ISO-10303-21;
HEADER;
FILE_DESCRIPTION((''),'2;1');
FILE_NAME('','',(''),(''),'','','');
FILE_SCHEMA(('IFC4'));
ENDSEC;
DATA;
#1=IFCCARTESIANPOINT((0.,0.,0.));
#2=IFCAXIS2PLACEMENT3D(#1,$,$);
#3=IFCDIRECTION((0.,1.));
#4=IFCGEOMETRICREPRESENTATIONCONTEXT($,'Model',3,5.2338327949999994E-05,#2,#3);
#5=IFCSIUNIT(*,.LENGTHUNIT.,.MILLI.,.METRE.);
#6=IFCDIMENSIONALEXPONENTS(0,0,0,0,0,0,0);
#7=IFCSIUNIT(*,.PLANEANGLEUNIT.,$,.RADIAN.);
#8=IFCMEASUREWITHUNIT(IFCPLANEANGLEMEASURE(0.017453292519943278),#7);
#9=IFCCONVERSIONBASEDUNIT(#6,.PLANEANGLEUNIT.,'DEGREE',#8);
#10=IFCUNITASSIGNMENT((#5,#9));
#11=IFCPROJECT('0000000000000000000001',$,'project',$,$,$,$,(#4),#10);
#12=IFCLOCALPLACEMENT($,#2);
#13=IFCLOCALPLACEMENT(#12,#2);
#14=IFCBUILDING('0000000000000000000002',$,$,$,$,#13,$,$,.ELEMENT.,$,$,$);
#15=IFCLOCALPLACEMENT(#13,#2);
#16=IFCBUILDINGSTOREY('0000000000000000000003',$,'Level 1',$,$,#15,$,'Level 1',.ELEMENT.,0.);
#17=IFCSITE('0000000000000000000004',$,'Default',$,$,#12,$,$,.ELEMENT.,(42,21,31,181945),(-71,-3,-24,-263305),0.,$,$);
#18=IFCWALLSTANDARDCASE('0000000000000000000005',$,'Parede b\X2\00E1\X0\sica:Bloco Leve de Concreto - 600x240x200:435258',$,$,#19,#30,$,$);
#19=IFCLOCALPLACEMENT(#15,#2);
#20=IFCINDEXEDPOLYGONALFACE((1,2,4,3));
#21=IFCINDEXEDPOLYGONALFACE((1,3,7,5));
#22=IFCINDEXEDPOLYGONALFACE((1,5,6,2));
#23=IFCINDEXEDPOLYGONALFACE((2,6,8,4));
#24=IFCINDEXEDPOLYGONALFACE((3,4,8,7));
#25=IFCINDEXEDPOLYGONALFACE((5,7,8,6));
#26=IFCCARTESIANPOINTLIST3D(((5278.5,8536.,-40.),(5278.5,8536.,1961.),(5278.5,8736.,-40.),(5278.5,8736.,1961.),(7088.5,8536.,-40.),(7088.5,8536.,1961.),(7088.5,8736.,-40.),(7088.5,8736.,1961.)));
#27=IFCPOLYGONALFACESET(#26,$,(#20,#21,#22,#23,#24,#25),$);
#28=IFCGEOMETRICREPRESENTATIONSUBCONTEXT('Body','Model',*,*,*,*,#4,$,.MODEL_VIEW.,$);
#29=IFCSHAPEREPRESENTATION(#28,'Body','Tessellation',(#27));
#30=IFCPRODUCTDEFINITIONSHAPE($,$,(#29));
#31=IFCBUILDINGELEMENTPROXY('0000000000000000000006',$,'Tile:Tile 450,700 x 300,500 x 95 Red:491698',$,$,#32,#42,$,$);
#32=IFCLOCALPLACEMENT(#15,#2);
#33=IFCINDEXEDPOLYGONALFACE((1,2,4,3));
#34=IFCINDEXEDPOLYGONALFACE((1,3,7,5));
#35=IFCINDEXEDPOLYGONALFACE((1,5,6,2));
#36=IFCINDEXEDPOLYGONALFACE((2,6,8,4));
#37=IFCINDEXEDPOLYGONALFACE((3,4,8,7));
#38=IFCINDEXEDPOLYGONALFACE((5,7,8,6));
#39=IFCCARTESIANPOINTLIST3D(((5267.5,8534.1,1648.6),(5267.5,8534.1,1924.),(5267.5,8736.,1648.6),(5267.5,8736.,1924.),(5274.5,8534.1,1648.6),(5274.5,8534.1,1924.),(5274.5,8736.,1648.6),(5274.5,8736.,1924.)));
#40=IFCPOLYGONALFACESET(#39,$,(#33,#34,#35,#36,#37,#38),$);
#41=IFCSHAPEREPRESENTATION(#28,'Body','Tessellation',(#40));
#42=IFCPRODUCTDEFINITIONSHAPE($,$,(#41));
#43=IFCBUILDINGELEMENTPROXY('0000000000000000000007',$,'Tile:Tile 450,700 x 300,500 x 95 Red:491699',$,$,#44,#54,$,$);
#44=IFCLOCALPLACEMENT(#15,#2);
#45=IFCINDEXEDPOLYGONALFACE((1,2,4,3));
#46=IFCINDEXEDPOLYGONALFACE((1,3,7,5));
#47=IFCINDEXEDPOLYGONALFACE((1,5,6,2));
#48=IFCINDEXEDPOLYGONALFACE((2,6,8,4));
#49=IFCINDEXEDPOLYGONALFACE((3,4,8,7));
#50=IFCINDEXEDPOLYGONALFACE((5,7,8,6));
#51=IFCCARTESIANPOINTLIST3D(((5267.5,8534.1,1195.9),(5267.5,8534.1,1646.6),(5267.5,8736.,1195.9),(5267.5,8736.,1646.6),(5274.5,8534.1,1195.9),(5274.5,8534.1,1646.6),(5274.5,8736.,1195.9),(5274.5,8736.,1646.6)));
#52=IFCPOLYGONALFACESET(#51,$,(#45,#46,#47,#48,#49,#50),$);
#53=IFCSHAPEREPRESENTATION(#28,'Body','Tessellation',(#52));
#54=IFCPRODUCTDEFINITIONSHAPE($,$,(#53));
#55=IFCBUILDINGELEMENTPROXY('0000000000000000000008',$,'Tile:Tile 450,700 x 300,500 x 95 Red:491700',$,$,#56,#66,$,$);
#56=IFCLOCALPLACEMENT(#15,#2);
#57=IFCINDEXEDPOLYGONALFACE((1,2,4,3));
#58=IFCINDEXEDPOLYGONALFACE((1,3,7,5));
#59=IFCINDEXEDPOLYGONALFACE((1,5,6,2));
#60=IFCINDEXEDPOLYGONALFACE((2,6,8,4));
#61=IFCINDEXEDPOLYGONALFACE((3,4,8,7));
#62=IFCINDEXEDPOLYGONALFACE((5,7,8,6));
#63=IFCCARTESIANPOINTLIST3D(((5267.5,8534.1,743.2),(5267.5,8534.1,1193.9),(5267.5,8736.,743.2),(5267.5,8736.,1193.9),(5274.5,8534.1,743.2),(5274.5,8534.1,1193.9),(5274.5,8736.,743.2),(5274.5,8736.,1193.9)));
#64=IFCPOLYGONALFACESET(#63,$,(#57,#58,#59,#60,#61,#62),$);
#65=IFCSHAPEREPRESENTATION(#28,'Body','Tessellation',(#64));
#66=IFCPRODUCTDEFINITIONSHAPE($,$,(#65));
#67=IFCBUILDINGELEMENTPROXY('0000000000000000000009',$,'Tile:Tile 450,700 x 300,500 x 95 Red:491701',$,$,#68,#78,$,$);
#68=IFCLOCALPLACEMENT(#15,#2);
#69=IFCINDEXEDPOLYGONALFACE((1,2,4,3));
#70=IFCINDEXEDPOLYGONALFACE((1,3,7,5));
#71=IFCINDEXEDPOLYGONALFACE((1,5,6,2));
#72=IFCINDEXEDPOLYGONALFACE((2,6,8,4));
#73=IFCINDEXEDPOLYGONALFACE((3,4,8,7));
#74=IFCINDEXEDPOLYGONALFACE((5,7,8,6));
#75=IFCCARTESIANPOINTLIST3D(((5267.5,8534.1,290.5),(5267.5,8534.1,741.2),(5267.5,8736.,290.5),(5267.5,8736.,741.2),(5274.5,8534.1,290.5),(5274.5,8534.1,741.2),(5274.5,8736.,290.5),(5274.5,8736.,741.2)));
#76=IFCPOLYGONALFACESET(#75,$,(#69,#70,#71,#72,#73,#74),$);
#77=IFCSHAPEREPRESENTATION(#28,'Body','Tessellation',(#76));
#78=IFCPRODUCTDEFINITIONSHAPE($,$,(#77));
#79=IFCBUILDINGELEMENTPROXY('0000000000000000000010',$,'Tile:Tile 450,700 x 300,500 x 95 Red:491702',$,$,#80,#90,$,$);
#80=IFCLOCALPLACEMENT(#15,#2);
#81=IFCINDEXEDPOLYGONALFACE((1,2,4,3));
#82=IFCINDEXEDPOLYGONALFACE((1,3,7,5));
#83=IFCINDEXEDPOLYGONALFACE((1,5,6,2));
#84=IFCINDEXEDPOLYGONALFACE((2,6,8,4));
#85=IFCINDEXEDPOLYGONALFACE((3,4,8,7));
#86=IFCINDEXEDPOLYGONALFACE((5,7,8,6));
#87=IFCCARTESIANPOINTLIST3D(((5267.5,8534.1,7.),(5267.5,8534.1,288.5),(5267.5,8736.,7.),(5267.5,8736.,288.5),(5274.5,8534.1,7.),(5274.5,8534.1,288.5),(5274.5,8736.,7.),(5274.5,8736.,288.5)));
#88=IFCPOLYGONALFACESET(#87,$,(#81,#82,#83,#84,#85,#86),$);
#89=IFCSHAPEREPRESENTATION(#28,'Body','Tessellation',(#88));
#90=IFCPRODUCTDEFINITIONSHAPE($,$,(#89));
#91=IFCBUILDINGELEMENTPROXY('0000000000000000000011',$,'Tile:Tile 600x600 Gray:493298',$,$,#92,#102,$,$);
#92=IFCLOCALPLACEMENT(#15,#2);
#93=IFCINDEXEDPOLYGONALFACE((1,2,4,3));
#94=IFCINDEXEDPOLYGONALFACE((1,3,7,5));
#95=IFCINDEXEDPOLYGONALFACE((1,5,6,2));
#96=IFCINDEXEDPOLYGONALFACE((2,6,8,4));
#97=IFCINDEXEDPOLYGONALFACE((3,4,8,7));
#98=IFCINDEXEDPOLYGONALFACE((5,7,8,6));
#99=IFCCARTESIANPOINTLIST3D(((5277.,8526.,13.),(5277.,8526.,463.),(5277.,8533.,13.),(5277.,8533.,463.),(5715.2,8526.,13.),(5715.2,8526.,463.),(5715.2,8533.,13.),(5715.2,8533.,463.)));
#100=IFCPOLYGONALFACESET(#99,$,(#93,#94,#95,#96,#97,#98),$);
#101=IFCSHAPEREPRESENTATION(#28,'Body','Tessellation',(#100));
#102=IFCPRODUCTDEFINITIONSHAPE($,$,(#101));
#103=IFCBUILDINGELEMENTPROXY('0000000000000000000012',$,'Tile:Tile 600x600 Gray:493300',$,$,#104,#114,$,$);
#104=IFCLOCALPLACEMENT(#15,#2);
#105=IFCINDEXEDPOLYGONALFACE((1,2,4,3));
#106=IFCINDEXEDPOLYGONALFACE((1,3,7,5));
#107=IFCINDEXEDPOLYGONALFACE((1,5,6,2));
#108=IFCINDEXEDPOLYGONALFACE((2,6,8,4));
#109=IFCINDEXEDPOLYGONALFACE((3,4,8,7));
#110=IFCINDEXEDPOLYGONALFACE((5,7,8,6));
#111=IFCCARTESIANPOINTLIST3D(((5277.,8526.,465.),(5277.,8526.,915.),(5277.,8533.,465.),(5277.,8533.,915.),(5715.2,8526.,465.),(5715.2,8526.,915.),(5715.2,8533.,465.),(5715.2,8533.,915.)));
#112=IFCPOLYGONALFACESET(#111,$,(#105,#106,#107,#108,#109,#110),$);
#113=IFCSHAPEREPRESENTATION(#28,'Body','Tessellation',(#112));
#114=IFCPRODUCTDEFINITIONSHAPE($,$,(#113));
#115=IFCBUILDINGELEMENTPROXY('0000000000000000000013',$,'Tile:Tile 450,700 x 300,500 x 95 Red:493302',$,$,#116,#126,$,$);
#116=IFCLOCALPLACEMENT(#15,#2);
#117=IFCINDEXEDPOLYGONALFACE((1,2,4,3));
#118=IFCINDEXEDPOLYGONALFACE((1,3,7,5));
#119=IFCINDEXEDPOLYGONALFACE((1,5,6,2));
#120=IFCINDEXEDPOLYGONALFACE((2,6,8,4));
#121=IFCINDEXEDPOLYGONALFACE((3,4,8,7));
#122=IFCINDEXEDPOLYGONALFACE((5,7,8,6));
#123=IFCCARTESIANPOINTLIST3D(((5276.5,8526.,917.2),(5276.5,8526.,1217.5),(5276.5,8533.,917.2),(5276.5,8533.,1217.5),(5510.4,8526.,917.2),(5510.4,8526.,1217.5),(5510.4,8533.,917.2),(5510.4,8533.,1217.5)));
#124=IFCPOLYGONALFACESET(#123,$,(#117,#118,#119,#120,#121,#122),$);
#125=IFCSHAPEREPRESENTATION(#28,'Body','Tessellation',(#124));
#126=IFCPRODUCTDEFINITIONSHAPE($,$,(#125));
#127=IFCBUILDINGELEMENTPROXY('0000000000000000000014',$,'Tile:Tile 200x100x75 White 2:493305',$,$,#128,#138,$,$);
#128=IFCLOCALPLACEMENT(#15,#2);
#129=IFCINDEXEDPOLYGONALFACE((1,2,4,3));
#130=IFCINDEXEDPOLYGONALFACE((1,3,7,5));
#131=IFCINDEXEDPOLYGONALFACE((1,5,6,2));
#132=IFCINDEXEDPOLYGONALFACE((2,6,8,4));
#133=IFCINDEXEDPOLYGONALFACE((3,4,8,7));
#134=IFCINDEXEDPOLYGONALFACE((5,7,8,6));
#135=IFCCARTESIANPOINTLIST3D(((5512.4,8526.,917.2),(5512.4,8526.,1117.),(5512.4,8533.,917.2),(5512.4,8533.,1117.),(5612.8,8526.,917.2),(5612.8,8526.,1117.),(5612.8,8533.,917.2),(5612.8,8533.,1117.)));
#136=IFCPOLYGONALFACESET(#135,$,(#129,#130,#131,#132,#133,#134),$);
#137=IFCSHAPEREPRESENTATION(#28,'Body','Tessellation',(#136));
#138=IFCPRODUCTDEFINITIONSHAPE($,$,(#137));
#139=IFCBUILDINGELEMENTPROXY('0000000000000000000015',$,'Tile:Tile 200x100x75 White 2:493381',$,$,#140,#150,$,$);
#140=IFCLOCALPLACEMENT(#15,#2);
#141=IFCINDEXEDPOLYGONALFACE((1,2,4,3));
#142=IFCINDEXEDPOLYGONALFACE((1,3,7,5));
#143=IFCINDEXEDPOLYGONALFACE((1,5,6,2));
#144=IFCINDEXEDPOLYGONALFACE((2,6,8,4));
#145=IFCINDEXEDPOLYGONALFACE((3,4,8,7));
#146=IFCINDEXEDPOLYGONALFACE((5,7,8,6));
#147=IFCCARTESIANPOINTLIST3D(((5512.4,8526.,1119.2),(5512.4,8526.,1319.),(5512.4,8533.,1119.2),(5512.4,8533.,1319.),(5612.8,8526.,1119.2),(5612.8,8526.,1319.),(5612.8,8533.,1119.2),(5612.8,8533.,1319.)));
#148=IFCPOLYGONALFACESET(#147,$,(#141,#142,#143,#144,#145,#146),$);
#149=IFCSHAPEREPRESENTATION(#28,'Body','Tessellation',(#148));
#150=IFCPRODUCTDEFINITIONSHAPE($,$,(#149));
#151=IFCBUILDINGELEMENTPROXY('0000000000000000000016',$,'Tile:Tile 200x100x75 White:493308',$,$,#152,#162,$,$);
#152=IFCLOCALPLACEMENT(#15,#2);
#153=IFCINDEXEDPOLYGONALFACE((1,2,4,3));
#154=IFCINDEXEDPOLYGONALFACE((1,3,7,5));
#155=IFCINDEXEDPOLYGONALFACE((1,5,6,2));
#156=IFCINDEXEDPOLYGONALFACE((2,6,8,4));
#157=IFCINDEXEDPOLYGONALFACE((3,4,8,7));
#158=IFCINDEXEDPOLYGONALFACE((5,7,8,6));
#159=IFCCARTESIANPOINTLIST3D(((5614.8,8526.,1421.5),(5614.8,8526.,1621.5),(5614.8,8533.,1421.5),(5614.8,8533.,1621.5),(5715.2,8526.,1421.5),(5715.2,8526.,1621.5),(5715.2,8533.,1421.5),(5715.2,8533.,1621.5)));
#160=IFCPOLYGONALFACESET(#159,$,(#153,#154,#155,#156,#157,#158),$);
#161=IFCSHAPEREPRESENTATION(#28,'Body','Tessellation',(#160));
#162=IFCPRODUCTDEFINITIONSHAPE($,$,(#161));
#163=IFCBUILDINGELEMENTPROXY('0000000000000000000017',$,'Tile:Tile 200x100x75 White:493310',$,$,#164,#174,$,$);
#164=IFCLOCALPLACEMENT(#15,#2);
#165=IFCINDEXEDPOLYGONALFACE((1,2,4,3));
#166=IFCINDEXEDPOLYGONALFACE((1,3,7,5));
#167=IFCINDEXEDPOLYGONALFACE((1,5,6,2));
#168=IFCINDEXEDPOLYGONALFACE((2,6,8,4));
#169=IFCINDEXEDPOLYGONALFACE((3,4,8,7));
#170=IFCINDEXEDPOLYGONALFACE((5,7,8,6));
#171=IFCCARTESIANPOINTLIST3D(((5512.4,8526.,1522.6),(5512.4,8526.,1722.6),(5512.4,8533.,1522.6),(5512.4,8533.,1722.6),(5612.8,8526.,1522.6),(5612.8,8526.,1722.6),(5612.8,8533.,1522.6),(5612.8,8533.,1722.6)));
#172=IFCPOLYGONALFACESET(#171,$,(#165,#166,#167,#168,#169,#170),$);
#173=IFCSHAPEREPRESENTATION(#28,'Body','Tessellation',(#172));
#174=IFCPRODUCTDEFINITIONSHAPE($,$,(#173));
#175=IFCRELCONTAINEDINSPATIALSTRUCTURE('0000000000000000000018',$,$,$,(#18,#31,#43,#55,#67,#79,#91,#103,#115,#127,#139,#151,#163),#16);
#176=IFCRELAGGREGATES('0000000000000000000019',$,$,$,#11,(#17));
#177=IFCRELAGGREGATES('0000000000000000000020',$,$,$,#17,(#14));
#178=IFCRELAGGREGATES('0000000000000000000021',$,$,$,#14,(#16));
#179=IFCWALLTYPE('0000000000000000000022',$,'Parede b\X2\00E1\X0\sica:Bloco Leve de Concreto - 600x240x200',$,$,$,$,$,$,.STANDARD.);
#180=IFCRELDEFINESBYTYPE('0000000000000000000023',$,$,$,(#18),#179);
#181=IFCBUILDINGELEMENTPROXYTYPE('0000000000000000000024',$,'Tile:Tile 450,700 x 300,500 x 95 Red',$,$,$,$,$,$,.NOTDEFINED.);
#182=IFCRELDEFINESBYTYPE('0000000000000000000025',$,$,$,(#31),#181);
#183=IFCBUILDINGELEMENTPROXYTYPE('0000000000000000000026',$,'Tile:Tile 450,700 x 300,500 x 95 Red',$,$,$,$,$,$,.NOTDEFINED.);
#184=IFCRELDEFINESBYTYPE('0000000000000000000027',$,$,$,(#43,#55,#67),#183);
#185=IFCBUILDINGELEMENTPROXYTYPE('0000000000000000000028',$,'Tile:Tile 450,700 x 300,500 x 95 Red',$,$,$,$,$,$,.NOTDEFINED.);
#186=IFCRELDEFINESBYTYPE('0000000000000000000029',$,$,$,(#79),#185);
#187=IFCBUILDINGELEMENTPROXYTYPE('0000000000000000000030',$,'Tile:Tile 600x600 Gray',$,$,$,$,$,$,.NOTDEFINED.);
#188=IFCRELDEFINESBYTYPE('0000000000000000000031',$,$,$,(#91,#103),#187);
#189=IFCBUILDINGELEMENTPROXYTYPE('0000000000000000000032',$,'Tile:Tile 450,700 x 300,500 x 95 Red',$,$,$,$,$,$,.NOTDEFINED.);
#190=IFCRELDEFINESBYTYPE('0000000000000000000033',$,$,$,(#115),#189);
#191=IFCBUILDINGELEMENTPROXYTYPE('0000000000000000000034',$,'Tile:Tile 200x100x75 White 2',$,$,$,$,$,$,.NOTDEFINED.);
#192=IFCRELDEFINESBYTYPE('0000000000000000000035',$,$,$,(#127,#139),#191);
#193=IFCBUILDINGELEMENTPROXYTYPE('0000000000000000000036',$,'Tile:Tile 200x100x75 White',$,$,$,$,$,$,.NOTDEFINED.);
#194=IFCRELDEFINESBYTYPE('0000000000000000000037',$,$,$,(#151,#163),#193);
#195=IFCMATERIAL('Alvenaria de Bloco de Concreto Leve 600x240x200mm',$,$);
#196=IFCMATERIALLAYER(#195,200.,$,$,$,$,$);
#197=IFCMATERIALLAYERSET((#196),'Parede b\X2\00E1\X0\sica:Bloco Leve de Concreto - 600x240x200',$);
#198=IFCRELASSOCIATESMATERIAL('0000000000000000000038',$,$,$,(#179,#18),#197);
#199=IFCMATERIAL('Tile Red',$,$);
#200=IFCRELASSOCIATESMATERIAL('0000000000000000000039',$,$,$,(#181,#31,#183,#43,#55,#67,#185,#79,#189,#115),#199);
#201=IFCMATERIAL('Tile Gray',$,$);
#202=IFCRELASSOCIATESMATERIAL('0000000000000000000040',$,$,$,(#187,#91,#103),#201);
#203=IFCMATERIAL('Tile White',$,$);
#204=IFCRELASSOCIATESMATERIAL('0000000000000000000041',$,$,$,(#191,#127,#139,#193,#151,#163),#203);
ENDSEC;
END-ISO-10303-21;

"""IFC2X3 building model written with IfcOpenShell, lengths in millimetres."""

from ifc_helpers import new_model, entity, si_unit, converted_unit, direction, frame, frame_2d, origin, origin_2d_with_axis, place, context, subcontext, project, spatial, rectangle, extrude, source, transform, mapped, material, layer, layer_set, layer_usage, type_object, type_shapes, element, save


model = new_model("IFC2X3")

# Units and contexts
model_context = context("Model", 3, precision=5.2338327949999994e-05, world=origin(), true_north=direction((0.0, 1.0)))
body_context = subcontext(model_context, "Body", "Model", "MODEL_VIEW")
ifc_project = project(units=[si_unit("LENGTHUNIT", "METRE", prefix="MILLI"), converted_unit("PLANEANGLEUNIT", "DEGREE", entity("IfcPlaneAngleMeasure", 0.017453292519943278), si_unit("PLANEANGLEUNIT", "RADIAN"), dimensions=[0, 0, 0, 0, 0, 0, 0])], contexts=[model_context])

# Site, building, storey
site_placement = place(None, origin())
site = spatial("IfcSite", under=ifc_project, at=site_placement, Name="Default", CompositionType="ELEMENT", RefLatitude=(42, 21, 31, 181945), RefLongitude=(-71, -3, -24, -263305), RefElevation=0.0)
building_placement = place(site_placement, origin())
building = spatial("IfcBuilding", under=site, at=building_placement, CompositionType="ELEMENT")
storey_placement = place(building_placement, origin())
storey = spatial("IfcBuildingStorey", under=building, at=storey_placement, Name="Level 1", LongName="Level 1", CompositionType="ELEMENT", Elevation=0.0)

# Wall
ifc_material_1 = material(Name="Alvenaria de Bloco de Concreto Leve 600x240x200mm")
ifc_layer = layer(ifc_material_1, 200.0)
ifc_layer_set = layer_set([ifc_layer], Name="Parede básica:Bloco Leve de Concreto - 600x240x200")
ifc_layer_usage = layer_usage(ifc_layer_set, "AXIS2", "NEGATIVE", 100.0)
wall_type = type_object("IfcWallType", Name="Parede básica:Bloco Leve de Concreto - 600x240x200", PredefinedType="STANDARD", material=ifc_layer_set)
wall_placement = place(storey_placement, frame((5278.5, 8636.0, -40.0)))
element("IfcWallStandardCase", 1, at=wall_placement, inside=storey, type_object=wall_type, material=ifc_layer_usage, Name="Parede básica:Bloco Leve de Concreto - 600x240x200:435258", context=body_context, shape_type="SweptSolid", body=[
    extrude(rectangle(XDim=1810.0, YDim=200.0, at=frame_2d((905.0, 0.0), x_axis=(-1.0, 0.0))), origin(), (0.0, 0.0, 1.0), 2001.0),
])

# Building element proxies
ifc_material_2 = material(Name="Tile Red")
building_element_proxy_type_1 = type_object("IfcBuildingElementProxyType", Name="Tile:Tile 450,700 x 300,500 x 95 Red", PredefinedType="NOTDEFINED", material=ifc_material_2)
shared_shape_1 = source(origin(), body_context, "Body", "SweptSolid", [
    extrude(rectangle(XDim=202.0, YDim=275.4, at=frame_2d((0.0, 0.0), x_axis=(1.0, 0.0))), frame((-101.0, -137.7, 0.0), z_axis=(0.0, 0.0, 1.0), x_axis=(-1.0, 0.0, 0.0)), (0.0, 0.0, 1.0), 7.0),
])
type_shapes(building_element_proxy_type_1, [shared_shape_1])
proxy_1_placement = place(storey_placement, frame((5274.5, 8736.0, 1648.6), z_axis=(-1.0, 0.0, 0.0), x_axis=(0.0, 1.0, 0.0)))
element("IfcBuildingElementProxy", 2, at=proxy_1_placement, inside=storey, type_object=building_element_proxy_type_1, material=ifc_material_2, Name="Tile:Tile 450,700 x 300,500 x 95 Red:491698", context=body_context, shape_type="MappedRepresentation", body=[
    mapped(shared_shape_1, transform((0.0, 0.0, 0.0), scale=1.0)),
])
building_element_proxy_type_2 = type_object("IfcBuildingElementProxyType", Name="Tile:Tile 450,700 x 300,500 x 95 Red", PredefinedType="NOTDEFINED", material=ifc_material_2)
shared_shape_2 = source(origin(), body_context, "Body", "SweptSolid", [
    extrude(rectangle(XDim=202.0, YDim=450.7, at=frame_2d((0.0, 0.0), x_axis=(1.0, 0.0))), frame((-101.0, -225.4, 0.0), z_axis=(0.0, 0.0, 1.0), x_axis=(-1.0, 0.0, 0.0)), (0.0, 0.0, 1.0), 7.0),
])
type_shapes(building_element_proxy_type_2, [shared_shape_2])
for number, where, z_axis, x_axis, name in (
    (3, (5274.5, 8736.0, 1195.9), (-1.0, 0.0, 0.0), (0.0, 1.0, 0.0), "Tile:Tile 450,700 x 300,500 x 95 Red:491699"),
    (4, (5274.5, 8736.0, 743.2), (-1.0, 0.0, 0.0), (0.0, 1.0, 0.0), "Tile:Tile 450,700 x 300,500 x 95 Red:491700"),
    (5, (5274.5, 8736.0, 290.5), (-1.0, 0.0, 0.0), (0.0, 1.0, 0.0), "Tile:Tile 450,700 x 300,500 x 95 Red:491701"),
):
    element("IfcBuildingElementProxy", number, at=place(storey_placement, frame(where, z_axis=z_axis, x_axis=x_axis)), inside=storey, type_object=building_element_proxy_type_2, material=ifc_material_2, Name=name, context=body_context, shape_type="MappedRepresentation", body=[
        mapped(shared_shape_2, transform((0.0, 0.0, 0.0), scale=1.0)),
    ])
building_element_proxy_type_3 = type_object("IfcBuildingElementProxyType", Name="Tile:Tile 450,700 x 300,500 x 95 Red", PredefinedType="NOTDEFINED", material=ifc_material_2)
shared_shape_3 = source(origin(), body_context, "Body", "SweptSolid", [
    extrude(rectangle(XDim=202.0, YDim=281.4, at=frame_2d((0.0, 0.0), x_axis=(1.0, 0.0))), frame((-101.0, -140.7, 0.0), z_axis=(0.0, 0.0, 1.0), x_axis=(-1.0, 0.0, 0.0)), (0.0, 0.0, 1.0), 7.0),
])
type_shapes(building_element_proxy_type_3, [shared_shape_3])
proxy_2_placement = place(storey_placement, frame((5274.5, 8736.0, 7.0), z_axis=(-1.0, 0.0, 0.0), x_axis=(0.0, 1.0, 0.0)))
element("IfcBuildingElementProxy", 6, at=proxy_2_placement, inside=storey, type_object=building_element_proxy_type_3, material=ifc_material_2, Name="Tile:Tile 450,700 x 300,500 x 95 Red:491702", context=body_context, shape_type="MappedRepresentation", body=[
    mapped(shared_shape_3, transform((0.0, 0.0, 0.0), scale=1.0)),
])
ifc_material_3 = material(Name="Tile Gray")
building_element_proxy_type_4 = type_object("IfcBuildingElementProxyType", Name="Tile:Tile 600x600 Gray", PredefinedType="NOTDEFINED", material=ifc_material_3)
shared_shape_4 = source(origin(), body_context, "Body", "SweptSolid", [
    extrude(rectangle(XDim=438.2, YDim=450.0, at=origin_2d_with_axis()), frame((-219.1, -225.0, 0.0), z_axis=(0.0, 0.0, 1.0), x_axis=(-1.0, 0.0, 0.0)), (0.0, 0.0, 1.0), 7.0),
])
type_shapes(building_element_proxy_type_4, [shared_shape_4])
for number, where, z_axis, x_axis, name in (
    (7, (5715.2, 8533.0, 463.0), (0.0, -1.0, 0.0), (1.0, 0.0, 0.0), "Tile:Tile 600x600 Gray:493298"),
    (8, (5715.2, 8533.0, 915.0), (0.0, -1.0, 0.0), (1.0, 0.0, 0.0), "Tile:Tile 600x600 Gray:493300"),
):
    element("IfcBuildingElementProxy", number, at=place(storey_placement, frame(where, z_axis=z_axis, x_axis=x_axis)), inside=storey, type_object=building_element_proxy_type_4, material=ifc_material_3, Name=name, context=body_context, shape_type="MappedRepresentation", body=[
        mapped(shared_shape_4, transform((0.0, 0.0, 0.0), scale=1.0)),
    ])
building_element_proxy_type_5 = type_object("IfcBuildingElementProxyType", Name="Tile:Tile 450,700 x 300,500 x 95 Red", PredefinedType="NOTDEFINED", material=ifc_material_2)
shared_shape_5 = source(origin(), body_context, "Body", "SweptSolid", [
    extrude(rectangle(XDim=233.9, YDim=300.3, at=frame_2d((0.0, 0.0), x_axis=(1.0, 0.0))), frame((-116.9, -150.2, 0.0), z_axis=(0.0, 0.0, 1.0), x_axis=(-1.0, 0.0, 0.0)), (0.0, 0.0, 1.0), 7.0),
])
type_shapes(building_element_proxy_type_5, [shared_shape_5])
proxy_3_placement = place(storey_placement, frame((5510.4, 8533.0, 1217.5), z_axis=(0.0, -1.0, 0.0), x_axis=(1.0, 0.0, 0.0)))
element("IfcBuildingElementProxy", 9, at=proxy_3_placement, inside=storey, type_object=building_element_proxy_type_5, material=ifc_material_2, Name="Tile:Tile 450,700 x 300,500 x 95 Red:493302", context=body_context, shape_type="MappedRepresentation", body=[
    mapped(shared_shape_5, transform((0.0, 0.0, 0.0), scale=1.0)),
])
ifc_material_4 = material(Name="Tile White")
building_element_proxy_type_6 = type_object("IfcBuildingElementProxyType", Name="Tile:Tile 200x100x75 White 2", PredefinedType="NOTDEFINED", material=ifc_material_4)
shared_shape_6 = source(origin(), body_context, "Body", "SweptSolid", [
    extrude(rectangle(XDim=199.8, YDim=100.4, at=frame_2d((0.0, 0.0), x_axis=(1.0, 0.0))), frame((-50.2, -99.9, 0.0), z_axis=(0.0, 0.0, 1.0), x_axis=(0.0, -1.0, 0.0)), (0.0, 0.0, 1.0), 7.0),
])
type_shapes(building_element_proxy_type_6, [shared_shape_6])
for number, where, z_axis, x_axis, name in (
    (10, (5612.8, 8533.0, 1117.0), (0.0, -1.0, 0.0), (1.0, 0.0, 0.0), "Tile:Tile 200x100x75 White 2:493305"),
    (11, (5612.8, 8533.0, 1319.0), (0.0, -1.0, 0.0), (1.0, 0.0, 0.0), "Tile:Tile 200x100x75 White 2:493381"),
):
    element("IfcBuildingElementProxy", number, at=place(storey_placement, frame(where, z_axis=z_axis, x_axis=x_axis)), inside=storey, type_object=building_element_proxy_type_6, material=ifc_material_4, Name=name, context=body_context, shape_type="MappedRepresentation", body=[
        mapped(shared_shape_6, transform((0.0, 0.0, 0.0), scale=1.0)),
    ])
building_element_proxy_type_7 = type_object("IfcBuildingElementProxyType", Name="Tile:Tile 200x100x75 White", PredefinedType="NOTDEFINED", material=ifc_material_4)
shared_shape_7 = source(origin(), body_context, "Body", "SweptSolid", [
    extrude(rectangle(XDim=200.0, YDim=100.4, at=frame_2d((0.0, 0.0), x_axis=(1.0, 0.0))), frame((-50.2, -100.0, 0.0), z_axis=(0.0, 0.0, 1.0), x_axis=(0.0, -1.0, 0.0)), (0.0, 0.0, 1.0), 7.0),
])
type_shapes(building_element_proxy_type_7, [shared_shape_7])
for number, where, z_axis, x_axis, name in (
    (12, (5715.2, 8533.0, 1621.5), (0.0, -1.0, 0.0), (1.0, 0.0, 0.0), "Tile:Tile 200x100x75 White:493308"),
    (13, (5612.8, 8533.0, 1722.6), (0.0, -1.0, 0.0), (1.0, 0.0, 0.0), "Tile:Tile 200x100x75 White:493310"),
):
    element("IfcBuildingElementProxy", number, at=place(storey_placement, frame(where, z_axis=z_axis, x_axis=x_axis)), inside=storey, type_object=building_element_proxy_type_7, material=ifc_material_4, Name=name, context=body_context, shape_type="MappedRepresentation", body=[
        mapped(shared_shape_7, transform((0.0, 0.0, 0.0), scale=1.0)),
    ])

save(model, "model.ifc")
